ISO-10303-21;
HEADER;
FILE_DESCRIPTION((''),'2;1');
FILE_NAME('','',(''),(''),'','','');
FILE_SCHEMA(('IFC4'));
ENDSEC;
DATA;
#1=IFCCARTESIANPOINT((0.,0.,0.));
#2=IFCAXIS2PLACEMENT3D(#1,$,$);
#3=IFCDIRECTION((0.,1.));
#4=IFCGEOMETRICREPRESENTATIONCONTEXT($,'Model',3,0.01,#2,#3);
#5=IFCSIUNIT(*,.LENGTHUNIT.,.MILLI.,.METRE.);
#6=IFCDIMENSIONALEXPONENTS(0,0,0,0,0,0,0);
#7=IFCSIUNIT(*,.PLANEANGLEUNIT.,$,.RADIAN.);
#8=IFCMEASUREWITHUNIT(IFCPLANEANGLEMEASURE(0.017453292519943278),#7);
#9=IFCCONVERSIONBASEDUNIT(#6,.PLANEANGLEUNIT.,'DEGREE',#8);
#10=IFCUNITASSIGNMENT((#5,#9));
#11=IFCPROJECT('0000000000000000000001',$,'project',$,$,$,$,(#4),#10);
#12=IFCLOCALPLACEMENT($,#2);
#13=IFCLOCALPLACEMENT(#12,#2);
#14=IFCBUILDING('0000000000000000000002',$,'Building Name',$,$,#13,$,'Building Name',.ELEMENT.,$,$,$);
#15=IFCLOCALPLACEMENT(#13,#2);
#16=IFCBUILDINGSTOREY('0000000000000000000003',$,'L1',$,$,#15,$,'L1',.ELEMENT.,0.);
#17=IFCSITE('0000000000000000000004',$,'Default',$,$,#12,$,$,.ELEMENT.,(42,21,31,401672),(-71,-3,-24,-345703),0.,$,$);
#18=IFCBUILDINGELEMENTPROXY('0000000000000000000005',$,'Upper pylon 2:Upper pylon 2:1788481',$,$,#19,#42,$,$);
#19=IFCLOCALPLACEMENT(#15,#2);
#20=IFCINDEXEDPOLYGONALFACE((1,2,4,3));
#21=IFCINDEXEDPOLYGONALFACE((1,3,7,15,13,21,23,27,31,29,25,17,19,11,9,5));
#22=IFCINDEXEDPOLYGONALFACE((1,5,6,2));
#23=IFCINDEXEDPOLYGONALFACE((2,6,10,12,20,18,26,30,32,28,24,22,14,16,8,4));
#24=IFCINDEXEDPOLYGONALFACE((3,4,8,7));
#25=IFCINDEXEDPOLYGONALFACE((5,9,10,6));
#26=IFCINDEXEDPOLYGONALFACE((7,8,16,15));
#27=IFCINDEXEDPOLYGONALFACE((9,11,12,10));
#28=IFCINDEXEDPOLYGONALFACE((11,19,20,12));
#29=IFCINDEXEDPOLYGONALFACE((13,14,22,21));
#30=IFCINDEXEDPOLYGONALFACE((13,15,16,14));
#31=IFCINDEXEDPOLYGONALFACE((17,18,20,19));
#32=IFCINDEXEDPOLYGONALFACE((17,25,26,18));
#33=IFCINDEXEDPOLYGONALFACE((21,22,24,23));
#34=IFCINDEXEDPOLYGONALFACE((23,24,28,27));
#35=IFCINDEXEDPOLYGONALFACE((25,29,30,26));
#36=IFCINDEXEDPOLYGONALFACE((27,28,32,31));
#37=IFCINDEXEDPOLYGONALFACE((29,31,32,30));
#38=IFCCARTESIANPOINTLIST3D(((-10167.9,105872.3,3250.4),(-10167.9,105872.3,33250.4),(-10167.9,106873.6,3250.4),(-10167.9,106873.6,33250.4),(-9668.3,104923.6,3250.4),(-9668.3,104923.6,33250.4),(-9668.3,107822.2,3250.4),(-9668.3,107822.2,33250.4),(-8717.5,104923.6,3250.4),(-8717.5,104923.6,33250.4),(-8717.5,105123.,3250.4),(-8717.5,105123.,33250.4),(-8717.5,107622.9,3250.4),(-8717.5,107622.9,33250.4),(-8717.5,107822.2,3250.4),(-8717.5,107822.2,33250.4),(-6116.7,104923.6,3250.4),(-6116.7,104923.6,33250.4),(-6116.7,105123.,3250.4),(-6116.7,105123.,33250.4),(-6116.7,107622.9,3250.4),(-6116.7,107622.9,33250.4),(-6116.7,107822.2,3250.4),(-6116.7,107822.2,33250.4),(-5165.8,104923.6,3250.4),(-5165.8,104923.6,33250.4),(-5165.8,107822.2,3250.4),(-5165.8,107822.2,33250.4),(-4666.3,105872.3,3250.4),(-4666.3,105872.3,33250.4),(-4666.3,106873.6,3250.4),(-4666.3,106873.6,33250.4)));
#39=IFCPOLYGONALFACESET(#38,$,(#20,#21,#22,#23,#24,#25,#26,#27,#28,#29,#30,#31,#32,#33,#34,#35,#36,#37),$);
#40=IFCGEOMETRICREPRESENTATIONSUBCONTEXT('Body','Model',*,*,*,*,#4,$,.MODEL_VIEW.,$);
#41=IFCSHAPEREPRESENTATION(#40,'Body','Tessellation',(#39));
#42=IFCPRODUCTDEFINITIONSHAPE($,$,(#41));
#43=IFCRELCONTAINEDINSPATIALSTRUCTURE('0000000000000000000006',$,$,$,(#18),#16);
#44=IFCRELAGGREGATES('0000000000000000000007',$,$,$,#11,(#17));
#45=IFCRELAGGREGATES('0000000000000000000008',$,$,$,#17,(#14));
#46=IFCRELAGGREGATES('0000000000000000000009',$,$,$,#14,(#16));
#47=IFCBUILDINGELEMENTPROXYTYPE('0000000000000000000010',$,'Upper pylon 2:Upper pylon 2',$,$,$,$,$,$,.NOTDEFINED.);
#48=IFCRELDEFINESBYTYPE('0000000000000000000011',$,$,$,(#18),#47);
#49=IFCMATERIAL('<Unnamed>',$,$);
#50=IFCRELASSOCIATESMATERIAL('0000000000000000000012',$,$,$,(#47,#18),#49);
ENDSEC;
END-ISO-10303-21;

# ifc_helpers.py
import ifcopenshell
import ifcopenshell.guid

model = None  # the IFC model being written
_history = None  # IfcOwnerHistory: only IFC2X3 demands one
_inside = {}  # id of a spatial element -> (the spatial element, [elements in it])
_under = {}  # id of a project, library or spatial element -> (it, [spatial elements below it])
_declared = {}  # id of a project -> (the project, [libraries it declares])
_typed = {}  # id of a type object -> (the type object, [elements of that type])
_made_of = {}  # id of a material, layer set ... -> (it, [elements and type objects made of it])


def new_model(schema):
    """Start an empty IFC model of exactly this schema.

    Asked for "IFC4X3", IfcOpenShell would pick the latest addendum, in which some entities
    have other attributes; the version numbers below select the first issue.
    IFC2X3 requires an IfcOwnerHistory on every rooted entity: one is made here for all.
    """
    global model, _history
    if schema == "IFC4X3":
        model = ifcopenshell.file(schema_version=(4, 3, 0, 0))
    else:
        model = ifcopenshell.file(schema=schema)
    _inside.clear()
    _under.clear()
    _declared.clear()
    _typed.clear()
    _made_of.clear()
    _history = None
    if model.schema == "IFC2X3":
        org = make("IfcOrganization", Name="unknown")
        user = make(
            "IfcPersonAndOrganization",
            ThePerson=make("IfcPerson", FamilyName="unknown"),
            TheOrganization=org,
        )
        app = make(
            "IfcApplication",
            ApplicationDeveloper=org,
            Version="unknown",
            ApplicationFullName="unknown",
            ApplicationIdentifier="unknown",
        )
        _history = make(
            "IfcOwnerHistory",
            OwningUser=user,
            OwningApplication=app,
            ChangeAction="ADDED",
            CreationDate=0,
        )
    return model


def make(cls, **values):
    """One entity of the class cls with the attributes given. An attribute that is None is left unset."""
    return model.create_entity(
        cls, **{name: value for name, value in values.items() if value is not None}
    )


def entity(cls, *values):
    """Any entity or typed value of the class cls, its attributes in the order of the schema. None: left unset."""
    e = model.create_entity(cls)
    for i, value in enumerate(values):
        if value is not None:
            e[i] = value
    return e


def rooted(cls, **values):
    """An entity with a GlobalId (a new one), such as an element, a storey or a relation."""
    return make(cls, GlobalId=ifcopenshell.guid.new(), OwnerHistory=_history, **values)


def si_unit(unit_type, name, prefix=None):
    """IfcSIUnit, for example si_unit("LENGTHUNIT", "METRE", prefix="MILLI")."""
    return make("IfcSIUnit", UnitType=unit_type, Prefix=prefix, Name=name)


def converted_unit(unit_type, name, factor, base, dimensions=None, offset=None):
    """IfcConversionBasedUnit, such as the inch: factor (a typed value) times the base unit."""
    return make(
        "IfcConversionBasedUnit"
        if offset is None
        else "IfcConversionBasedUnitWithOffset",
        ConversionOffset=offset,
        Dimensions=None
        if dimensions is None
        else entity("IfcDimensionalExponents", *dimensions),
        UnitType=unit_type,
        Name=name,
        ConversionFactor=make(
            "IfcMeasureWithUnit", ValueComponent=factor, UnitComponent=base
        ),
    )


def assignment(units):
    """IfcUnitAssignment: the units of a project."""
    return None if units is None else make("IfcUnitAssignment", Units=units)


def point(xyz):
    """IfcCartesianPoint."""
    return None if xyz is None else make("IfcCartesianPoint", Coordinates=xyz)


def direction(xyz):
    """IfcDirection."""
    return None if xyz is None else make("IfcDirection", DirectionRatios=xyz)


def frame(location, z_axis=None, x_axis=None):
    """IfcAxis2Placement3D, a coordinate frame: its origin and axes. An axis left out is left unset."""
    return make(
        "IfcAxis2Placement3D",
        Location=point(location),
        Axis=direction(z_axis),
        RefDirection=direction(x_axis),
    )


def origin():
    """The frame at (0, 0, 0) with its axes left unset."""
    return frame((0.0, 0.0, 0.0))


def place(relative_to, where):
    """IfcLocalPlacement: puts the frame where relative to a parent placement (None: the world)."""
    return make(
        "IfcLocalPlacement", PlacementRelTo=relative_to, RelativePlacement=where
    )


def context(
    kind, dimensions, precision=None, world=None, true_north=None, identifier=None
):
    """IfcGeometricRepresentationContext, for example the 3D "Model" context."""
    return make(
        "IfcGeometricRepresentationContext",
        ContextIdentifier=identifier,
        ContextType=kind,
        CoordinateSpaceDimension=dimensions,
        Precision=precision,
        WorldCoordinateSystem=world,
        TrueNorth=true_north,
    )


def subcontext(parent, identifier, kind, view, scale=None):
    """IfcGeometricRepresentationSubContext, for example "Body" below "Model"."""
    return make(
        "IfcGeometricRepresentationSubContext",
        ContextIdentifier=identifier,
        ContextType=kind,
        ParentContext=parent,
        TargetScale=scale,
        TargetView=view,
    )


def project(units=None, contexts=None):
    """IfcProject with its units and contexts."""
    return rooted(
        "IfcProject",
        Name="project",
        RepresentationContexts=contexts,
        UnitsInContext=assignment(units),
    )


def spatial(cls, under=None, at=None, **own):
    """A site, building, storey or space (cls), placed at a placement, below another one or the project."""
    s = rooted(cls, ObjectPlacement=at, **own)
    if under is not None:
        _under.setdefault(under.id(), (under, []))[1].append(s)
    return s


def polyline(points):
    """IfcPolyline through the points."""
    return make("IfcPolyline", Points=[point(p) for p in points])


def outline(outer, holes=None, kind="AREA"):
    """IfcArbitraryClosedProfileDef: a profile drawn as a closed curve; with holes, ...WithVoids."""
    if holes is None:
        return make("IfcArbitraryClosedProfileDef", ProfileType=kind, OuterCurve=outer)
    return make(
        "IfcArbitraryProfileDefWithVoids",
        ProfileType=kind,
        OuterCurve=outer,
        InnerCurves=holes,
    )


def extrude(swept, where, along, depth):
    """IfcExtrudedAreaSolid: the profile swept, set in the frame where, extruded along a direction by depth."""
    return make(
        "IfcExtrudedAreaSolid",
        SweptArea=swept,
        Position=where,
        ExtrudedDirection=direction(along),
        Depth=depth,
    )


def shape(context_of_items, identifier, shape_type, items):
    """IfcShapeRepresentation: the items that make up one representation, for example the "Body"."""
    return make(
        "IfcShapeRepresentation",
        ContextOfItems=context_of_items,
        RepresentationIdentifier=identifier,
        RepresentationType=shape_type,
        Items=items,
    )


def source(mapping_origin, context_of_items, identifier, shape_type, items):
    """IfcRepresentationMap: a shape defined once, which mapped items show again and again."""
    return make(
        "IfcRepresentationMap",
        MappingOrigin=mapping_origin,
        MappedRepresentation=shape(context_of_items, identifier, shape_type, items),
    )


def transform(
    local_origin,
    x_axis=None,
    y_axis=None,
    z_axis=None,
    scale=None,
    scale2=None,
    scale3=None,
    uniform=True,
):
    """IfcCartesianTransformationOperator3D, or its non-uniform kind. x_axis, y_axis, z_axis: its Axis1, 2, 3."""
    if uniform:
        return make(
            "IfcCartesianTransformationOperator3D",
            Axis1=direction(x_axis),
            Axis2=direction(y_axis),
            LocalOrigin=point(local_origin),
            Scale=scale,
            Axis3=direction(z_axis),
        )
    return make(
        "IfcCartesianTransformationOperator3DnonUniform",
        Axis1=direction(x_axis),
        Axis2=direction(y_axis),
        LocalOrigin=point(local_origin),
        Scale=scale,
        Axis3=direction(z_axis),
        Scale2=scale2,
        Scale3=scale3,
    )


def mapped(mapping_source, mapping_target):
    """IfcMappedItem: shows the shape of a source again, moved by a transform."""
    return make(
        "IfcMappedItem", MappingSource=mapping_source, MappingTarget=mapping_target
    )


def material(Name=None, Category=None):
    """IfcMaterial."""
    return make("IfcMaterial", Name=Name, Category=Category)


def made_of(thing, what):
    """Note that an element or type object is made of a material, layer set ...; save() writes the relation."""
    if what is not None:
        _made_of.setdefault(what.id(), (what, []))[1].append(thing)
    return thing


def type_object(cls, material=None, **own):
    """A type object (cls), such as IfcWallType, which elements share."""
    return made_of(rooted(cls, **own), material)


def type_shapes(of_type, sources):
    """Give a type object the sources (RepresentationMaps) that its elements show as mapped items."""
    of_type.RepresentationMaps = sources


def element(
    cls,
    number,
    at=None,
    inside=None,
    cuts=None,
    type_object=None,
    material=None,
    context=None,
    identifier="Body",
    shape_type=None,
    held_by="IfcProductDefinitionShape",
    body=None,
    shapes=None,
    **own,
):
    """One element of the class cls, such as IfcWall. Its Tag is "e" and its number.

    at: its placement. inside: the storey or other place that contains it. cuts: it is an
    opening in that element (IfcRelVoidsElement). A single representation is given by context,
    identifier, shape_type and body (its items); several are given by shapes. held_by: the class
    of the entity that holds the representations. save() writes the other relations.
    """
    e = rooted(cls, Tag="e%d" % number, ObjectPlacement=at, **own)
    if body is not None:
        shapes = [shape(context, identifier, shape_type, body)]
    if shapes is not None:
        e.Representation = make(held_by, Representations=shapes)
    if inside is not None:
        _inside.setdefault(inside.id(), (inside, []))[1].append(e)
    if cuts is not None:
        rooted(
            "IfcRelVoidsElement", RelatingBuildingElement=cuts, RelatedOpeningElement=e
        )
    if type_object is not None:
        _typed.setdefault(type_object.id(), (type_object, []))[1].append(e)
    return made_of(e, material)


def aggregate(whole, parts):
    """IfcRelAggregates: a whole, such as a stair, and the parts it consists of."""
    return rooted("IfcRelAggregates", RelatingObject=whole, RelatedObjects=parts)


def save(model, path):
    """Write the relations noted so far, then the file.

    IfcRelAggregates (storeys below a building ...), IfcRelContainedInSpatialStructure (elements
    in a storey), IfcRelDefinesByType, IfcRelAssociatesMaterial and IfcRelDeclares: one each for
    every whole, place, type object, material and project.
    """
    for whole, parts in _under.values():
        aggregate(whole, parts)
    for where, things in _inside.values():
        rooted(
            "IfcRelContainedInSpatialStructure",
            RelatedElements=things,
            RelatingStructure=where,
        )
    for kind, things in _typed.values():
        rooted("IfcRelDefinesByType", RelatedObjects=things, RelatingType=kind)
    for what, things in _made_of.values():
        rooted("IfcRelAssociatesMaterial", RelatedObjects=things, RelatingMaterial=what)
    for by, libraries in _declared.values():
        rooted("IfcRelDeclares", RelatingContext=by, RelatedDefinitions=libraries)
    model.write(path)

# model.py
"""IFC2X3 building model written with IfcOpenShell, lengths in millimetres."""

from ifc_helpers import new_model, entity, si_unit, converted_unit, direction, frame, origin, place, context, subcontext, project, spatial, polyline, outline, extrude, source, transform, mapped, material, type_object, type_shapes, element, save


model = new_model("IFC2X3")

# Units and contexts
model_context = context("Model", 3, precision=0.01, world=origin(), true_north=direction((0.0, 1.0)))
body_context = subcontext(model_context, "Body", "Model", "MODEL_VIEW")
ifc_project = project(units=[si_unit("LENGTHUNIT", "METRE", prefix="MILLI"), converted_unit("PLANEANGLEUNIT", "DEGREE", entity("IfcPlaneAngleMeasure", 0.017453292519943278), si_unit("PLANEANGLEUNIT", "RADIAN"), dimensions=[0, 0, 0, 0, 0, 0, 0])], contexts=[model_context])

# Site, building, storey
site_placement = place(None, origin())
site = spatial("IfcSite", under=ifc_project, at=site_placement, Name="Default", CompositionType="ELEMENT", RefLatitude=(42, 21, 31, 401672), RefLongitude=(-71, -3, -24, -345703), RefElevation=0.0)
building_placement = place(site_placement, origin())
building = spatial("IfcBuilding", under=site, at=building_placement, Name="Building Name", LongName="Building Name", CompositionType="ELEMENT")
storey_placement = place(building_placement, origin())
storey = spatial("IfcBuildingStorey", under=building, at=storey_placement, Name="L1", LongName="L1", CompositionType="ELEMENT", Elevation=0.0)

# Shared definitions
ifc_material_1 = material(Name="<Unnamed>")

# Building element proxy
building_element_proxy_type = type_object("IfcBuildingElementProxyType", Name="Upper pylon 2:Upper pylon 2", PredefinedType="NOTDEFINED", material=ifc_material_1)
shared_shape_1 = source(origin(), body_context, "Body", "SweptSolid", [
    extrude(outline(polyline([(1300.4, -1449.3), (2251.3, -1449.3), (2750.8, -500.6), (2750.8, 500.6), (2251.3, 1449.3), (1300.4, 1449.3), (1300.4, 1249.9), (-1300.4, 1249.9), (-1300.4, 1449.3), (-2251.3, 1449.3), (-2750.8, 500.6), (-2750.8, -500.6), (-2251.3, -1449.3), (-1300.4, -1449.3), (-1300.4, -1249.9), (1300.4, -1249.9), (1300.4, -1449.3)])), frame((68629.5, 106372.9, 3609.7), z_axis=(0.0, 0.0, 1.0), x_axis=(-1.0, 0.0, 0.0)), (0.0, 0.0, 1.0), 30000.0),
])
type_shapes(building_element_proxy_type, [shared_shape_1])
proxy_placement = place(storey_placement, frame((-76046.6, 0.0, -359.3)))
element("IfcBuildingElementProxy", 1, at=proxy_placement, inside=storey, type_object=building_element_proxy_type, material=ifc_material_1, Name="Upper pylon 2:Upper pylon 2:1788481", context=body_context, shape_type="MappedRepresentation", body=[
    mapped(shared_shape_1, transform((0.0, 0.0, 0.0), scale=1.0)),
])

save(model, "model.ifc")
